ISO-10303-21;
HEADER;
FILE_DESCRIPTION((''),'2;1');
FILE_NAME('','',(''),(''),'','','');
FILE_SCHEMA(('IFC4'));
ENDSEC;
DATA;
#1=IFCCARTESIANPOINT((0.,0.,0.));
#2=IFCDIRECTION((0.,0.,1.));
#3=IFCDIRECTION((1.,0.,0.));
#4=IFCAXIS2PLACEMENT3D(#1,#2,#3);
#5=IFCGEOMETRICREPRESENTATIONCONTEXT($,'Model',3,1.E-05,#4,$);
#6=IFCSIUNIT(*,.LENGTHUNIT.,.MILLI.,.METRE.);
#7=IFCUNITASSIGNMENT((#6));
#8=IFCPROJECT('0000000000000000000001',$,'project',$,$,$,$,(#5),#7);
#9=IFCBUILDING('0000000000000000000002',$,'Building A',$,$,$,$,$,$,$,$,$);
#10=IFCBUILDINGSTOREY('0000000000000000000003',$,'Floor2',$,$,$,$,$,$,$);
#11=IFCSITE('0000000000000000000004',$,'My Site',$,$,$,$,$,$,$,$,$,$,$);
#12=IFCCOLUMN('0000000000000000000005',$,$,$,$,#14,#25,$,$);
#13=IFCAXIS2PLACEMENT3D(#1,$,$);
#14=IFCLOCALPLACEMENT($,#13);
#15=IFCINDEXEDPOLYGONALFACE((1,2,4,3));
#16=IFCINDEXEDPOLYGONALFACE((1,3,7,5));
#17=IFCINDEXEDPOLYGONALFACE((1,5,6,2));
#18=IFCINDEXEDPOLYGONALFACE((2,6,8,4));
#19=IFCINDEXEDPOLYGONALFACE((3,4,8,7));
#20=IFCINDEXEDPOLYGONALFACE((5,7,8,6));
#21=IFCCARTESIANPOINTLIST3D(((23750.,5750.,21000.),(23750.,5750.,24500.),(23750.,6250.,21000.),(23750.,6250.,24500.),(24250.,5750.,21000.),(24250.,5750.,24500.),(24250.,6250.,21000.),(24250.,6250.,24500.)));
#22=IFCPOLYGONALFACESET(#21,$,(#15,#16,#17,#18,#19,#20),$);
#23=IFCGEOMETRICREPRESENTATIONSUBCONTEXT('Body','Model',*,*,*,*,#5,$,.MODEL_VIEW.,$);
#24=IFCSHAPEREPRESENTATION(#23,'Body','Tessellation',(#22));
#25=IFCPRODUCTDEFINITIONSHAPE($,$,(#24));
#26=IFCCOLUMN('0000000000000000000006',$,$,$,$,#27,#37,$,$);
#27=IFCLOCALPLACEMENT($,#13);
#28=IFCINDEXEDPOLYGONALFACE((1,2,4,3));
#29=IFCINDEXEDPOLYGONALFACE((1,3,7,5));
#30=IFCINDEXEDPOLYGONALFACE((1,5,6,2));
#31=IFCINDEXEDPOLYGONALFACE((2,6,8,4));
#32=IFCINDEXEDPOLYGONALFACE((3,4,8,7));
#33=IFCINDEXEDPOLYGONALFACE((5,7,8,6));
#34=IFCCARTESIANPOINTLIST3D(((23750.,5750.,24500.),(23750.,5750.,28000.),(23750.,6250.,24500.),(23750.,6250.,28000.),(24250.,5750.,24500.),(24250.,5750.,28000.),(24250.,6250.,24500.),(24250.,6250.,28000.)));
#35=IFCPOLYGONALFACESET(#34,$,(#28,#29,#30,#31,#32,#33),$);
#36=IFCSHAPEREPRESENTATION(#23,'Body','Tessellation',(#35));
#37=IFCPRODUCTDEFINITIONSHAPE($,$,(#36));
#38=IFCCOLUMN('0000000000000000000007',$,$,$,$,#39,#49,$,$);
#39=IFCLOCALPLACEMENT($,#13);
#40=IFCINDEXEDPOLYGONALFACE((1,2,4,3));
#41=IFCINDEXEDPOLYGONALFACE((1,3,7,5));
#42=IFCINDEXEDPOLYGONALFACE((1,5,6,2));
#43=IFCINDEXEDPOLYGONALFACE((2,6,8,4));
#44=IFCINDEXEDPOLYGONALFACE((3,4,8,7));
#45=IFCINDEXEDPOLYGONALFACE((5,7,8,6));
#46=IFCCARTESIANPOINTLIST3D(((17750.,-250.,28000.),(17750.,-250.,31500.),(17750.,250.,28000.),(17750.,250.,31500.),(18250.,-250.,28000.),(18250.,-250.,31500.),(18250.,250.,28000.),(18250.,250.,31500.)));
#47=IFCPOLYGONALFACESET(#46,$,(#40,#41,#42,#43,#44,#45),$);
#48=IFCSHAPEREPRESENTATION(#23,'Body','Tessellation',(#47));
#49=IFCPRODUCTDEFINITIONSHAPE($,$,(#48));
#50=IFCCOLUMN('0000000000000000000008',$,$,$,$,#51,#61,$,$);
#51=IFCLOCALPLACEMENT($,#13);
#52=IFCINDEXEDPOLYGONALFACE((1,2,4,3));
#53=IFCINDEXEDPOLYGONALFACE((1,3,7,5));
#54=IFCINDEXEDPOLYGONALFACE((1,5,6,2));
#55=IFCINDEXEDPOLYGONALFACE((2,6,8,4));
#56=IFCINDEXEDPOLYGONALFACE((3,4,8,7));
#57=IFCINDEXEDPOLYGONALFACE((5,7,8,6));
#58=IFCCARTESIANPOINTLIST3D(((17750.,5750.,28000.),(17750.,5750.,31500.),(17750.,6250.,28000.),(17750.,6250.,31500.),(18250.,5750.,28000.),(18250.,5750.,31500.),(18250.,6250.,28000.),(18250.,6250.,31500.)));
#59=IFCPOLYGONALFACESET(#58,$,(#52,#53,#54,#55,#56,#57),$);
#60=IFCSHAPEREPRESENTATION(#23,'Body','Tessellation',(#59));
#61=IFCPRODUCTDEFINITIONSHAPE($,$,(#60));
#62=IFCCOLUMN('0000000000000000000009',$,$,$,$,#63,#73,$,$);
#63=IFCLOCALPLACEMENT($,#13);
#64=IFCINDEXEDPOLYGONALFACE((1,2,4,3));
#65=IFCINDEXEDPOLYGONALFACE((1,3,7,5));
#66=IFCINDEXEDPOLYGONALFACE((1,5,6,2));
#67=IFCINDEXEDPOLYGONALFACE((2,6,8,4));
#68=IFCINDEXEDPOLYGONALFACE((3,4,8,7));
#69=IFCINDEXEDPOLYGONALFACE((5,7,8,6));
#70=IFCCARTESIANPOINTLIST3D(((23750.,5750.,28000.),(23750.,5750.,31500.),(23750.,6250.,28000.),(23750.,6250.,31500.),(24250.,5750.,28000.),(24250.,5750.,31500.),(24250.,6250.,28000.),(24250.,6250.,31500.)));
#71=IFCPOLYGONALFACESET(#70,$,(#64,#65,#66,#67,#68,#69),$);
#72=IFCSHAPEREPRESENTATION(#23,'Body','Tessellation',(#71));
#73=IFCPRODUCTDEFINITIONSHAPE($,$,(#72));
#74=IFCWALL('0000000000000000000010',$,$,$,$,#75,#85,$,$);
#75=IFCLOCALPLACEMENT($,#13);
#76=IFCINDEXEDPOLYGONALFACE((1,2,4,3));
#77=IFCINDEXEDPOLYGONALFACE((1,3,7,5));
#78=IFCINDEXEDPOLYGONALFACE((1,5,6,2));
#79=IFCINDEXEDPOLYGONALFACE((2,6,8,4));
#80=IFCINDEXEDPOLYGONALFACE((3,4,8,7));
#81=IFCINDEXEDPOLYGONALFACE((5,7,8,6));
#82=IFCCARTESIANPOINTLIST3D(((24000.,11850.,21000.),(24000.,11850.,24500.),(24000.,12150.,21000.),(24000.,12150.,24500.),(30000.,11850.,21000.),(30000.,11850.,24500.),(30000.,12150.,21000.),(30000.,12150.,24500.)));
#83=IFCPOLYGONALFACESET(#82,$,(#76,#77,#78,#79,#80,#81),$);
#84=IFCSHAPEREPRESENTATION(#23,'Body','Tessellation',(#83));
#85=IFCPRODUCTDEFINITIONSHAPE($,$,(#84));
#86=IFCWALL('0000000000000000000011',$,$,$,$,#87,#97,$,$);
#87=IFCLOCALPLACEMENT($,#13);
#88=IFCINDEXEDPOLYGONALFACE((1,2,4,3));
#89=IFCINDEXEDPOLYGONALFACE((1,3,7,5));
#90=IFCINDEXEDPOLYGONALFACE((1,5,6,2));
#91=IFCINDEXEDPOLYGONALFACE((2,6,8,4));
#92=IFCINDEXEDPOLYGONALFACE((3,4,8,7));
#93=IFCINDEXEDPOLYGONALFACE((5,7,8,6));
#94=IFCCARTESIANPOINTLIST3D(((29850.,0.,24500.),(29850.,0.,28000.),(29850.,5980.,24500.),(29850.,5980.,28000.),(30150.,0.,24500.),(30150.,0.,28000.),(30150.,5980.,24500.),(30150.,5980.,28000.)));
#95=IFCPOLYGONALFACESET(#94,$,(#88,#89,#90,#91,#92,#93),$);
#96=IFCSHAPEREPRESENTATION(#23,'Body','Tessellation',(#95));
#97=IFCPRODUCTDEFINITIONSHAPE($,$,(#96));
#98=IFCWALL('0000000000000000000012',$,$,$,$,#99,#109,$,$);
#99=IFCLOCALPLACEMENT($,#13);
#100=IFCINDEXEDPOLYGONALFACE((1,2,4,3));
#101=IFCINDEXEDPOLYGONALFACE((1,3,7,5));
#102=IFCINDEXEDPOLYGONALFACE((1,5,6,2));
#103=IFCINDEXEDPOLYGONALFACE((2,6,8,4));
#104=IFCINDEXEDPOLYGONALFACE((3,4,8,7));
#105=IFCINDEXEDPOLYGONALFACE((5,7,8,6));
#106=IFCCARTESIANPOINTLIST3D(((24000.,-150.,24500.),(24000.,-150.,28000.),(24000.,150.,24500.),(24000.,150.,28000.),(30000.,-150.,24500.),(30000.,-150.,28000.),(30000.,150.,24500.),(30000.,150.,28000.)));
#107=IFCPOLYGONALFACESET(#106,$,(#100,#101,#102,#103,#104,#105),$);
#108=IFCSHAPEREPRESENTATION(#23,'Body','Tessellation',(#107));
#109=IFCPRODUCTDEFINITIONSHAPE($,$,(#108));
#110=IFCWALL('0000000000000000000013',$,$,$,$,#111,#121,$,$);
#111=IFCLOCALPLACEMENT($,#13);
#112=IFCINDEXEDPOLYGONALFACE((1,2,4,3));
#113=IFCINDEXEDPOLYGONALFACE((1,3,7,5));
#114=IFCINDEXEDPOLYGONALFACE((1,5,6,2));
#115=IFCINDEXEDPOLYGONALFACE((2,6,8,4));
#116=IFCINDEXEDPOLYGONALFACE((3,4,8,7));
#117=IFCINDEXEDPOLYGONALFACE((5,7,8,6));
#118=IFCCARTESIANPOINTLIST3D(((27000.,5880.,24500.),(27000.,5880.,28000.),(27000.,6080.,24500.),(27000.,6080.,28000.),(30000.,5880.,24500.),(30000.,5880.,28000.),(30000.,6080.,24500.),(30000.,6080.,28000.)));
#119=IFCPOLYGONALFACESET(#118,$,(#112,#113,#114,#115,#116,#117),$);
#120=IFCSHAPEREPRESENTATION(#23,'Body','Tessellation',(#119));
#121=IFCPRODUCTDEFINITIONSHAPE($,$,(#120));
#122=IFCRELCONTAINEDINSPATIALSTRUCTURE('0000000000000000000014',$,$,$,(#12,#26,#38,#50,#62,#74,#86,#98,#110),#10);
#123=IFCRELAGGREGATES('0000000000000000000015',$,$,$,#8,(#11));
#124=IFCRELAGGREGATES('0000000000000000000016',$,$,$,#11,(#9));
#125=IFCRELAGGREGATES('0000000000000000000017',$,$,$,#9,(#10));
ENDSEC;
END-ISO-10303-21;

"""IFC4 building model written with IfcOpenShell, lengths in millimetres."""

from ifc_helpers import new_model, si_unit, frame, origin_with_axes, place, context, subcontext, project, spatial, line, indexed_curve, outline, extrude, element, save


model = new_model("IFC4")

# Units and contexts
model_context = context("Model", 3, precision=1e-05, world=origin_with_axes())
body_context = subcontext(model_context, "Body", "Model", "MODEL_VIEW")
ifc_project = project(units=[si_unit("LENGTHUNIT", "METRE", prefix="MILLI")], contexts=[model_context])

# Site, building, storey
site = spatial("IfcSite", under=ifc_project, Name="My Site")
building = spatial("IfcBuilding", under=site, Name="Building A")
storey = spatial("IfcBuildingStorey", under=building, Name="Floor2")

# Columns
for number, where, z_axis, x_axis in (
    (1, (24000.0, 6000.0, 21000.0), (0.0, 0.0, 1.0), (1.0, 0.0, 0.0)),
    (2, (24000.0, 6000.0, 24500.0), (0.0, 0.0, 1.0), (1.0, 0.0, 0.0)),
    (3, (18000.0, 0.0, 28000.0), (0.0, 0.0, 1.0), (1.0, 0.0, 0.0)),
    (4, (18000.0, 6000.0, 28000.0), (0.0, 0.0, 1.0), (1.0, 0.0, 0.0)),
    (5, (24000.0, 6000.0, 28000.0), (0.0, 0.0, 1.0), (1.0, 0.0, 0.0)),
):
    element("IfcColumn", number, at=place(None, frame(where, z_axis=z_axis, x_axis=x_axis)), inside=storey, context=body_context, shape_type="SweptSolid", body=[
        extrude(outline(indexed_curve([(-250.0, -250.0), (250.0, -250.0), (250.0, 250.0), (-250.0, 250.0)], segments=[line(1, 2, 3, 4, 1)])), origin_with_axes(), (0.0, 0.0, 1.0), 3500.0),
    ])

# Walls
wall_1_placement = place(None, frame((24000.0, 11850.0, 21000.0), z_axis=(0.0, 0.0, 1.0), x_axis=(1.0, 0.0, 0.0)))
element("IfcWall", 6, at=wall_1_placement, inside=storey, context=body_context, shape_type="SweptSolid", body=[
    extrude(outline(indexed_curve([(0.0, 0.0), (0.0, 300.0), (6000.0, 300.0), (6000.0, 0.0), (0.0, 0.0)], self_intersect=False)), origin_with_axes(), (0.0, 0.0, 1.0), 3500.0),
])
wall_2_placement = place(None, frame((29850.0, 5980.0, 24500.0), z_axis=(0.0, 0.0, 1.0), x_axis=(0.0, -1.0, 0.0)))
element("IfcWall", 7, at=wall_2_placement, inside=storey, context=body_context, shape_type="SweptSolid", body=[
    extrude(outline(indexed_curve([(0.0, 0.0), (0.0, 300.0), (5980.0, 300.0), (5980.0, 0.0), (0.0, 0.0)], self_intersect=False)), origin_with_axes(), (0.0, 0.0, 1.0), 3500.0),
])
wall_3_placement = place(None, frame((30000.0, 150.0, 24500.0), z_axis=(0.0, 0.0, 1.0), x_axis=(-1.0, 0.0, 0.0)))
element("IfcWall", 8, at=wall_3_placement, inside=storey, context=body_context, shape_type="SweptSolid", body=[
    extrude(outline(indexed_curve([(0.0, 0.0), (0.0, 300.0), (6000.0, 300.0), (6000.0, 0.0), (0.0, 0.0)], self_intersect=False)), origin_with_axes(), (0.0, 0.0, 1.0), 3500.0),
])
wall_4_placement = place(None, frame((27000.0, 5880.0, 24500.0), z_axis=(0.0, 0.0, 1.0), x_axis=(1.0, 0.0, 0.0)))
element("IfcWall", 9, at=wall_4_placement, inside=storey, context=body_context, shape_type="SweptSolid", body=[
    extrude(outline(indexed_curve([(0.0, 0.0), (0.0, 200.0), (3000.0, 200.0), (3000.0, 0.0), (0.0, 0.0)], self_intersect=False)), origin_with_axes(), (0.0, 0.0, 1.0), 3500.0),
])

save(model, "model.ifc")
